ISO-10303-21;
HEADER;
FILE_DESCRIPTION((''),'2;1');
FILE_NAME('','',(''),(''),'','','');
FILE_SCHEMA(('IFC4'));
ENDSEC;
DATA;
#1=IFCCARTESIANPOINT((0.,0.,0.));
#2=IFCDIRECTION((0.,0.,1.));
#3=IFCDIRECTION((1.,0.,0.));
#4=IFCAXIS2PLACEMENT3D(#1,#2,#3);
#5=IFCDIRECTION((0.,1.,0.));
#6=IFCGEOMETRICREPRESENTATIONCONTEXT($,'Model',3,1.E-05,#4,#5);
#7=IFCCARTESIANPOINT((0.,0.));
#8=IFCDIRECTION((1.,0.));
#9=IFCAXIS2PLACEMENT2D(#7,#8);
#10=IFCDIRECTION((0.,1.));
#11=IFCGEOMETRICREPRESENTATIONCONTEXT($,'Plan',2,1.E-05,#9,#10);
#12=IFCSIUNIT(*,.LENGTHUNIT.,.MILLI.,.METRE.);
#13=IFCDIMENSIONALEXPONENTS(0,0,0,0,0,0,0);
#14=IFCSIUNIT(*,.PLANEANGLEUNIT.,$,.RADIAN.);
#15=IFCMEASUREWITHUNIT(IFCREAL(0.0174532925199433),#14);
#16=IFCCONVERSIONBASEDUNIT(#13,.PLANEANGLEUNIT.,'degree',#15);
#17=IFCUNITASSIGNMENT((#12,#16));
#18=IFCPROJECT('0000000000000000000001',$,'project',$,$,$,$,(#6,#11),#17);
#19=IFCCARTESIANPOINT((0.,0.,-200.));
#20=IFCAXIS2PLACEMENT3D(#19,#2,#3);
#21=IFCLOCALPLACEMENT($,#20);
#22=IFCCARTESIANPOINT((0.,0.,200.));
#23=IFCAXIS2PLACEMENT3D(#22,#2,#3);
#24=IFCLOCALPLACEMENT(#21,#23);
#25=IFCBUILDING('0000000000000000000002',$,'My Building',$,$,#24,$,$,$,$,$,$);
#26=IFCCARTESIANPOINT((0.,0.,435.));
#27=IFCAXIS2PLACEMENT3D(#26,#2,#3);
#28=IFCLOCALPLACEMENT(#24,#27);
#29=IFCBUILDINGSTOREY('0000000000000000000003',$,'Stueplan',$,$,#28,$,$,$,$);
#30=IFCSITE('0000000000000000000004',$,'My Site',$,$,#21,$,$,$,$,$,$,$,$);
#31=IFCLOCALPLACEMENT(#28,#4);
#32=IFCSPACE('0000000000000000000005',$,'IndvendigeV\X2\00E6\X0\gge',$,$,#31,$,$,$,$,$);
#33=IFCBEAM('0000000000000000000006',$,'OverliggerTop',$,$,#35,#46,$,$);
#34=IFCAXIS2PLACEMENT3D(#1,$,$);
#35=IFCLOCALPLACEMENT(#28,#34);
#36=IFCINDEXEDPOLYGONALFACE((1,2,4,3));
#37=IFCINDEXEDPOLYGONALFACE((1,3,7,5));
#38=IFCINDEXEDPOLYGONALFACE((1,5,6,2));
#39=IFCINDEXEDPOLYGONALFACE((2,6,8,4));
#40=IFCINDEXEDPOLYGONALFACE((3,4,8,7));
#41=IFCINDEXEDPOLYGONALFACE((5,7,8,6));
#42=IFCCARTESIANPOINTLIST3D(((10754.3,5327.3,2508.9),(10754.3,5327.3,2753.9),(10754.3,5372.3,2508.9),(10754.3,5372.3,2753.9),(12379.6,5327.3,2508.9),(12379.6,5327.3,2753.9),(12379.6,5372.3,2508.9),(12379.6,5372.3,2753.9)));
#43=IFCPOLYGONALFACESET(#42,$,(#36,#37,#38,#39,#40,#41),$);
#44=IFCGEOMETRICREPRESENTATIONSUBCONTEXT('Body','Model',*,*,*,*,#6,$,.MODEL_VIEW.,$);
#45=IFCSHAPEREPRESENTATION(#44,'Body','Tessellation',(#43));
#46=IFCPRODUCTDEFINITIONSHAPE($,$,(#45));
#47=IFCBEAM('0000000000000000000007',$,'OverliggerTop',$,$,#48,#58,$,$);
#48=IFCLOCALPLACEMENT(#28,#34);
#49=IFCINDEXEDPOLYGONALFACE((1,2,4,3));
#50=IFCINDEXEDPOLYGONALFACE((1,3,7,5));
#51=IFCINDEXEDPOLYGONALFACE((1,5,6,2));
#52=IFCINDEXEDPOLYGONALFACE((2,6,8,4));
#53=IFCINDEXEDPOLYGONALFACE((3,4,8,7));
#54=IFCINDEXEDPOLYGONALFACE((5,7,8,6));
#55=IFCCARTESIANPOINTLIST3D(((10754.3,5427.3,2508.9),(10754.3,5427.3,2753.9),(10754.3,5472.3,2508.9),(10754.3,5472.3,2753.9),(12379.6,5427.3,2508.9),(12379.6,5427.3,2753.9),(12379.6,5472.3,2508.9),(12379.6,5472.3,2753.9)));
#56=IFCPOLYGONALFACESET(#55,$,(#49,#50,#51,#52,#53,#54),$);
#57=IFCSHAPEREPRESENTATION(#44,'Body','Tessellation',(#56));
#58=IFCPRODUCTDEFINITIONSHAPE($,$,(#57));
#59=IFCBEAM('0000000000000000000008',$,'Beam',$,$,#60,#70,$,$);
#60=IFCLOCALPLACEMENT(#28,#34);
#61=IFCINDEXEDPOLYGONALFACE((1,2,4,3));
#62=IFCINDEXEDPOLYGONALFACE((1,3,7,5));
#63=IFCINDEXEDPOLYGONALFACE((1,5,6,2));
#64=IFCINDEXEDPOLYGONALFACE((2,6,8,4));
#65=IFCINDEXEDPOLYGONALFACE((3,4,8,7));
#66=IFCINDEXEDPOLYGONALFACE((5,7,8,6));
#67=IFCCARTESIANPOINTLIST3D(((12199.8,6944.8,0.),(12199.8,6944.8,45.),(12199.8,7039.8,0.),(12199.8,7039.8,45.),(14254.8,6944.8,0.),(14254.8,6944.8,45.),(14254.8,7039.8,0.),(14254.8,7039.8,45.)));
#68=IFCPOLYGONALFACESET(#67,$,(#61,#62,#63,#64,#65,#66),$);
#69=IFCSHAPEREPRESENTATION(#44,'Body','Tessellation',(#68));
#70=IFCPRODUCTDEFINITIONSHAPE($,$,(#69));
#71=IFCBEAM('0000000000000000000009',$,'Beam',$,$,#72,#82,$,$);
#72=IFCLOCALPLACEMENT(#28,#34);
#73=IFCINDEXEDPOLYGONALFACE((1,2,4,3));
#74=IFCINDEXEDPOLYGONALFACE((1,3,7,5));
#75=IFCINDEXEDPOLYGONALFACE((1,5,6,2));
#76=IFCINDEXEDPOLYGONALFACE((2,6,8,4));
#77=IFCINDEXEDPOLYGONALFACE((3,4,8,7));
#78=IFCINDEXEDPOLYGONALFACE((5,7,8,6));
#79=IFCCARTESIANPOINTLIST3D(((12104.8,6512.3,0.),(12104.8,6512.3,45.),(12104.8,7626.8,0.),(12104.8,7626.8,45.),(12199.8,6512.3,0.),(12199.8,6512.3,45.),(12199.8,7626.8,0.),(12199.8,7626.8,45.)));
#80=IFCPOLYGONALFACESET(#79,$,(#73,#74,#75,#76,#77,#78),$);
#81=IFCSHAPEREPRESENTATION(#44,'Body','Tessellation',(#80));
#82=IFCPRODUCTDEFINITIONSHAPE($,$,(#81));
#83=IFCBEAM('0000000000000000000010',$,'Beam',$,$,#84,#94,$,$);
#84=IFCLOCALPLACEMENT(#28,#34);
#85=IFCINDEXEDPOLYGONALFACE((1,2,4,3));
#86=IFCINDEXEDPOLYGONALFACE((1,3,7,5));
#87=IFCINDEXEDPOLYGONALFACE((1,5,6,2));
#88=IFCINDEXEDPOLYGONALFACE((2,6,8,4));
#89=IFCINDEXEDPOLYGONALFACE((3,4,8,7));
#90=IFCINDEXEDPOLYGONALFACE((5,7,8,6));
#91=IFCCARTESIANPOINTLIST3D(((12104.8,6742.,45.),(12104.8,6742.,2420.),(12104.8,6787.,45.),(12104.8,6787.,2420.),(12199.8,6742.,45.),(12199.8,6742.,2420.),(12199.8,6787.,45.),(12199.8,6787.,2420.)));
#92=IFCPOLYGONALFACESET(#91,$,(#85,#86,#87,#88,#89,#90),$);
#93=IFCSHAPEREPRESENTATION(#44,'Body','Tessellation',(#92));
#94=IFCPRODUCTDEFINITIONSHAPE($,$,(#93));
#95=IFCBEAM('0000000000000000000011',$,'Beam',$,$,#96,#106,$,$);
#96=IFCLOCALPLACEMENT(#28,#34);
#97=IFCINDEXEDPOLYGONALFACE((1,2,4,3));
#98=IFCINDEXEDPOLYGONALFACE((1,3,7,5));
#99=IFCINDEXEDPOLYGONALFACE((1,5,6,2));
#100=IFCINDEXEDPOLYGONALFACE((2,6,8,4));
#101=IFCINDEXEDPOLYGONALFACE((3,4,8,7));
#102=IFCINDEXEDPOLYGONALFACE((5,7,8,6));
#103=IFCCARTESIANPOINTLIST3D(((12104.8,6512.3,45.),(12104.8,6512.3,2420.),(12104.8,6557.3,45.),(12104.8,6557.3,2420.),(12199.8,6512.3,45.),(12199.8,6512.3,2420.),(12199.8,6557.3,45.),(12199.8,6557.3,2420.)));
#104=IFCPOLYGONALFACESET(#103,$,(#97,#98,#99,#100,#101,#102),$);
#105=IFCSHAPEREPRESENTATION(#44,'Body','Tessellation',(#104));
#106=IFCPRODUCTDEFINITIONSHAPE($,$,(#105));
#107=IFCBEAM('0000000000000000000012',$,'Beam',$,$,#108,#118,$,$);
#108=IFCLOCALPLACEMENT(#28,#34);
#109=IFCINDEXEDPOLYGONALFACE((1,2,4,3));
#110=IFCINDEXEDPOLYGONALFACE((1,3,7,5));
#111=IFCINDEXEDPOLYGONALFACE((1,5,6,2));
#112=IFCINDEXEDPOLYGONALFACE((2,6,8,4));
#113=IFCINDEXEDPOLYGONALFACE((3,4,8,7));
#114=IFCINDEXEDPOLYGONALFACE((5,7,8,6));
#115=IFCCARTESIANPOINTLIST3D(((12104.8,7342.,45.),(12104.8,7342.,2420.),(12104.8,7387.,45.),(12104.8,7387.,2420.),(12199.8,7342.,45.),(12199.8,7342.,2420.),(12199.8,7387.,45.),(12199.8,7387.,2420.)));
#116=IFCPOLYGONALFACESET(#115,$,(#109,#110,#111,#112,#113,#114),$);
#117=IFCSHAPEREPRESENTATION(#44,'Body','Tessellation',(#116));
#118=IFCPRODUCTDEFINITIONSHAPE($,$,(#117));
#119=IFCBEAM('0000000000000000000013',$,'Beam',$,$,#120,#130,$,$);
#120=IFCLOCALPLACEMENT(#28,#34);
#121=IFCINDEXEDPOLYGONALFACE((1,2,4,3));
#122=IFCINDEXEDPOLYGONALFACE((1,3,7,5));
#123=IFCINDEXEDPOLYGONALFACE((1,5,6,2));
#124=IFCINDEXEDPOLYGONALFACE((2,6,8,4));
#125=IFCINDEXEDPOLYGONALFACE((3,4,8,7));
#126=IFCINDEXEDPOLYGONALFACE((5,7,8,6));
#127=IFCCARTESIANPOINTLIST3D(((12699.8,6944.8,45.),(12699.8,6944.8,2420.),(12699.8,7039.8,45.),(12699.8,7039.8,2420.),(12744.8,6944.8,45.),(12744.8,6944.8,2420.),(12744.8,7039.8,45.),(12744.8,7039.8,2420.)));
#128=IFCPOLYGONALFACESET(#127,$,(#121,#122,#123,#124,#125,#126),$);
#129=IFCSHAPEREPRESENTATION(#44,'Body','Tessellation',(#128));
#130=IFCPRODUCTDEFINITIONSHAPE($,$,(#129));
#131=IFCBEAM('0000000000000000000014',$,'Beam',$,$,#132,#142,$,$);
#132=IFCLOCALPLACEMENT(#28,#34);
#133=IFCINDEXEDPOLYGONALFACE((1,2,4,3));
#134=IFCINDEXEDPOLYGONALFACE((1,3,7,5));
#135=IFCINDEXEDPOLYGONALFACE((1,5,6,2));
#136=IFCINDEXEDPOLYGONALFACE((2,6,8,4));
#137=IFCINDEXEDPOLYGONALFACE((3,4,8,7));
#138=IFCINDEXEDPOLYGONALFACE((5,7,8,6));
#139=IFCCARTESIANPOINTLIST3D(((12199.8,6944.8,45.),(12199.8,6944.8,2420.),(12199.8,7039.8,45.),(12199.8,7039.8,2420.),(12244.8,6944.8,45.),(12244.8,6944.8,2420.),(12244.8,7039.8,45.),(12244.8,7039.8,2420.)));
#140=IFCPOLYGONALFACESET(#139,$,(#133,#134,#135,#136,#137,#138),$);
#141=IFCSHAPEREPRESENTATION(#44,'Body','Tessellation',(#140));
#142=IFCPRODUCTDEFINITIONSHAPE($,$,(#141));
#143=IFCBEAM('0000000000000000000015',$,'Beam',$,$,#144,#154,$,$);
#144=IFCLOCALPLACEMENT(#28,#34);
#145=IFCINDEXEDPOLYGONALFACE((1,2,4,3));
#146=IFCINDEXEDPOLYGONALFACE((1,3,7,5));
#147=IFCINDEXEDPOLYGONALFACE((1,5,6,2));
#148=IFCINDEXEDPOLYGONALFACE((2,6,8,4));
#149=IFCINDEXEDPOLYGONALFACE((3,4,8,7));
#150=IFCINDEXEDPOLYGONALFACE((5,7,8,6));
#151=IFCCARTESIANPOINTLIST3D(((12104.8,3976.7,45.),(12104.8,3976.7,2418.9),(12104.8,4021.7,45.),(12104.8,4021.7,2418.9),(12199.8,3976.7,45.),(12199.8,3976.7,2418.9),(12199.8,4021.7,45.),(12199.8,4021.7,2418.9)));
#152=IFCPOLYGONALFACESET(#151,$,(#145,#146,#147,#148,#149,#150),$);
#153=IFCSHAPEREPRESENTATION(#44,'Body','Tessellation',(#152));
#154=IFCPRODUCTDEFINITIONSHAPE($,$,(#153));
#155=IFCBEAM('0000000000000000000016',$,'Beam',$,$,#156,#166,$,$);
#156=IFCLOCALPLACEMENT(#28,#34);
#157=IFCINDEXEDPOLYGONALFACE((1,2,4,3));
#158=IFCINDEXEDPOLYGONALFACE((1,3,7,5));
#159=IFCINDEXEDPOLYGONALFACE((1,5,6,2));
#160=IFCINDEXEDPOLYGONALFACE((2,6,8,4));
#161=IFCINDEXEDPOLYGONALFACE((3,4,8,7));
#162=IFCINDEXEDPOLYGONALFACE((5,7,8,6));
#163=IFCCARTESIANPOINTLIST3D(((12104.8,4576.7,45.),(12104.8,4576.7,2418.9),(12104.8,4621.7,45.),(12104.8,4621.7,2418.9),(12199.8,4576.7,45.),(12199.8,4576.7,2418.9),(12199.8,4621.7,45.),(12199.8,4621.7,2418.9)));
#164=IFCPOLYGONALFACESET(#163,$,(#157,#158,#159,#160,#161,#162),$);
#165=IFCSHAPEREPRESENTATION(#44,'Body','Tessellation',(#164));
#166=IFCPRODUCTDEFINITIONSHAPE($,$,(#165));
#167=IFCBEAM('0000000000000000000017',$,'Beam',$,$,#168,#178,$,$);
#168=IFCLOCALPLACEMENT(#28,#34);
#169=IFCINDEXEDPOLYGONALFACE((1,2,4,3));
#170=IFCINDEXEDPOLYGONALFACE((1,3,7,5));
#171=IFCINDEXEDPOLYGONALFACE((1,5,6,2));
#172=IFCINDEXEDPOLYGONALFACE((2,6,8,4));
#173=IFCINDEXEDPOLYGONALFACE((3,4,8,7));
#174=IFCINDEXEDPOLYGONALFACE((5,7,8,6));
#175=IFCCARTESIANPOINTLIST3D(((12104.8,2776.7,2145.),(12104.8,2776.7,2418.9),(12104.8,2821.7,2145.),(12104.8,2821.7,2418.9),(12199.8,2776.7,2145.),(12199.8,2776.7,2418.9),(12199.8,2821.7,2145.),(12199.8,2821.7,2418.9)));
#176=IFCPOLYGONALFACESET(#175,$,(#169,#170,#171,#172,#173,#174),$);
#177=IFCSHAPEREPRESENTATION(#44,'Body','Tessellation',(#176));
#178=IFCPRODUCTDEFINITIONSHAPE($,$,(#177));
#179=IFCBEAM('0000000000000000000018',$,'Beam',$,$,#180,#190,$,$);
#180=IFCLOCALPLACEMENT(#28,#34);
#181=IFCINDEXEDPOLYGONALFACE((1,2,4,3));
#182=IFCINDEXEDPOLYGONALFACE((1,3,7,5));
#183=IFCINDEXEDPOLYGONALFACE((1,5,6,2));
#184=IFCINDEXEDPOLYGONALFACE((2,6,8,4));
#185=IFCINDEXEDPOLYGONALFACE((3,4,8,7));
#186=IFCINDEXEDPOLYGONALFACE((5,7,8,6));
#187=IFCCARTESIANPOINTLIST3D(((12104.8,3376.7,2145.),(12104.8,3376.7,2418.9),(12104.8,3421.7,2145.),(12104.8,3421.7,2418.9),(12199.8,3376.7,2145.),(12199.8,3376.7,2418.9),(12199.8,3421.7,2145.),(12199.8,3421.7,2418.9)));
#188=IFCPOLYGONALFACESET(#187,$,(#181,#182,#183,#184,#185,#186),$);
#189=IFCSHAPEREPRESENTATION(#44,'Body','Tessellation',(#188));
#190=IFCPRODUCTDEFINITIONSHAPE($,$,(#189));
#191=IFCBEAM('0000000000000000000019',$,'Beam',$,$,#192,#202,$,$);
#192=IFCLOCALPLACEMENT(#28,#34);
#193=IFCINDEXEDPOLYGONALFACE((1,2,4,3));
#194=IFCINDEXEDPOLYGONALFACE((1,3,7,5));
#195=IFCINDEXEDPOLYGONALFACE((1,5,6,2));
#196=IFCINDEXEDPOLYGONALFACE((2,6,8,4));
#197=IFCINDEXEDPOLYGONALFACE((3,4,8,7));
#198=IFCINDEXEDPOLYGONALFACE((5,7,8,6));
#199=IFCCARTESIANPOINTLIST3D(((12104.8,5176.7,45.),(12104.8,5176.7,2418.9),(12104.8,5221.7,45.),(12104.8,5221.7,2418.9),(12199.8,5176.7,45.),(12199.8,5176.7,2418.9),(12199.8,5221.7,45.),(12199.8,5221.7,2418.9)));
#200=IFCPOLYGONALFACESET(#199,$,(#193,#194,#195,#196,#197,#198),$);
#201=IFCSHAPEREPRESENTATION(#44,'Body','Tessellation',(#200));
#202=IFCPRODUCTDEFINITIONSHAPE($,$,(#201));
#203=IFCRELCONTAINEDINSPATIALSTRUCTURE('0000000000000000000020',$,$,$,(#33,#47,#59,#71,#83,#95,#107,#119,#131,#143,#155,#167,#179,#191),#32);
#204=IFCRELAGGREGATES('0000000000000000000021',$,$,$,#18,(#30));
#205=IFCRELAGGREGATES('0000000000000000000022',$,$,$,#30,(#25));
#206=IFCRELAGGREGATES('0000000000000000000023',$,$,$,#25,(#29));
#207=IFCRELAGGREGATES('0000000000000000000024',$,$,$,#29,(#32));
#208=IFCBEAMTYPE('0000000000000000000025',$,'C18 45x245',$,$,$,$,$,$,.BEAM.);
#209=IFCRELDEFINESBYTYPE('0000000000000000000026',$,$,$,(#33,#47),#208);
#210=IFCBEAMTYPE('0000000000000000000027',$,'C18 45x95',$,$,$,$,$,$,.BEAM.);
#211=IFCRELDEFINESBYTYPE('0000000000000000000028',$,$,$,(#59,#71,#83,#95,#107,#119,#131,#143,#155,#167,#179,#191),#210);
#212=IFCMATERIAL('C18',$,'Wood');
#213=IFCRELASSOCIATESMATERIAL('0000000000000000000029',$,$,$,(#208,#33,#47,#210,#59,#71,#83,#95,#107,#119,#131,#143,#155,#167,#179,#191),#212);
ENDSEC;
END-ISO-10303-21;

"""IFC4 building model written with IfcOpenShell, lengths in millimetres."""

from ifc_helpers import new_model, entity, si_unit, converted_unit, direction, frame, origin_with_axes, origin_2d_with_axis, place, context, subcontext, project, spatial, rectangle, extrude, material, material_profile, profile_set, profile_usage, type_object, element, save


model = new_model("IFC4")

# Units and contexts
model_context = context("Model", 3, precision=1e-05, world=origin_with_axes(), true_north=direction((0.0, 1.0, 0.0)))
plan_context = context("Plan", 2, precision=1e-05, world=origin_2d_with_axis(), true_north=direction((0.0, 1.0)))
body_context_1 = subcontext(model_context, "Body", "Model", "MODEL_VIEW")
ifc_project = project(units=[si_unit("LENGTHUNIT", "METRE", prefix="MILLI"), converted_unit("PLANEANGLEUNIT", "degree", entity("IfcReal", 0.0174532925199433), si_unit("PLANEANGLEUNIT", "RADIAN"), dimensions=[0, 0, 0, 0, 0, 0, 0])], contexts=[model_context, plan_context])

# Site, building, storey, space
site_placement = place(None, frame((0.0, 0.0, -200.0), z_axis=(0.0, 0.0, 1.0), x_axis=(1.0, 0.0, 0.0)))
site = spatial("IfcSite", under=ifc_project, at=site_placement, Name="My Site")
building_placement = place(site_placement, frame((0.0, 0.0, 200.0), z_axis=(0.0, 0.0, 1.0), x_axis=(1.0, 0.0, 0.0)))
building = spatial("IfcBuilding", under=site, at=building_placement, Name="My Building")
storey_placement = place(building_placement, frame((0.0, 0.0, 435.0), z_axis=(0.0, 0.0, 1.0), x_axis=(1.0, 0.0, 0.0)))
storey = spatial("IfcBuildingStorey", under=building, at=storey_placement, Name="Stueplan")
space_1_placement = place(storey_placement, frame((0.0, 0.0, 0.0), z_axis=(0.0, 0.0, 1.0), x_axis=(1.0, 0.0, 0.0)))
space_1 = spatial("IfcSpace", under=storey, at=space_1_placement, Name="IndvendigeVægge")

# Beams
ifc_material = material(Name="C18", Category="Wood")
ifc_material_profile_1 = material_profile(ifc_material, rectangle(XDim=45.0, YDim=245.0), Name="concrete")
ifc_profile_set_1 = profile_set([ifc_material_profile_1], Name="woodStructural")
ifc_profile_usage_1 = profile_usage(ifc_profile_set_1)
beam_type_1 = type_object("IfcBeamType", Name="C18 45x245", PredefinedType="BEAM", material=ifc_profile_set_1)
beam_1_placement = place(space_1_placement, frame((12379.6, 5349.8, 2631.4), z_axis=(-1.0, 0.0, 0.0), x_axis=(0.0, 1.0, 0.0)))
element("IfcBeam", 1, at=beam_1_placement, inside=space_1, type_object=beam_type_1, material=ifc_profile_usage_1, Name="OverliggerTop", context=body_context_1, shape_type="SweptSolid", body=[
    extrude(rectangle(XDim=45.0, YDim=245.0), origin_with_axes(), (0.0, 0.0, 1.0), 1625.3),
])
ifc_profile_usage_2 = profile_usage(ifc_profile_set_1)
beam_2_placement = place(space_1_placement, frame((12379.6, 5449.8, 2631.4), z_axis=(-1.0, 0.0, 0.0), x_axis=(0.0, 1.0, 0.0)))
element("IfcBeam", 2, at=beam_2_placement, inside=space_1, type_object=beam_type_1, material=ifc_profile_usage_2, Name="OverliggerTop", context=body_context_1, shape_type="SweptSolid", body=[
    extrude(rectangle(XDim=45.0, YDim=245.0), origin_with_axes(), (0.0, 0.0, 1.0), 1625.3),
])
ifc_material_profile_2 = material_profile(ifc_material, rectangle(XDim=45.0, YDim=95.0))
ifc_profile_set_2 = profile_set([ifc_material_profile_2], Name="woodStructural")
ifc_profile_usage_3 = profile_usage(ifc_profile_set_2, cardinal=5)
beam_type_2 = type_object("IfcBeamType", Name="C18 45x95", PredefinedType="BEAM", material=ifc_profile_set_2)
beam_3_placement = place(space_1_placement, frame((12199.8, 6992.3, 22.5), z_axis=(1.0, 0.0, 0.0), x_axis=(0.0, 0.0, 1.0)))
element("IfcBeam", 3, at=beam_3_placement, inside=space_1, type_object=beam_type_2, material=ifc_profile_usage_3, Name="Beam", context=body_context_1, shape_type="SweptSolid", body=[
    extrude(rectangle(XDim=45.0, YDim=95.0), origin_with_axes(), (0.0, 0.0, 1.0), 2055.0),
])
ifc_profile_usage_4 = profile_usage(ifc_profile_set_2, cardinal=5)
beam_4_placement = place(space_1_placement, frame((12152.3, 6512.3, 22.5), z_axis=(0.0, 1.0, 0.0), x_axis=(0.0, 0.0, 1.0)))
element("IfcBeam", 4, at=beam_4_placement, inside=space_1, type_object=beam_type_2, material=ifc_profile_usage_4, Name="Beam", context=body_context_1, shape_type="SweptSolid", body=[
    extrude(rectangle(XDim=45.0, YDim=95.0), origin_with_axes(), (0.0, 0.0, 1.0), 1114.5),
])
ifc_profile_usage_5 = profile_usage(ifc_profile_set_2)
beam_5_placement = place(space_1_placement, frame((12152.3, 6764.5, 45.0), z_axis=(0.0, 0.0, 1.0), x_axis=(0.0, 1.0, 0.0)))
element("IfcBeam", 5, at=beam_5_placement, inside=space_1, type_object=beam_type_2, material=ifc_profile_usage_5, Name="Beam", context=body_context_1, shape_type="SweptSolid", body=[
    extrude(rectangle(XDim=45.0, YDim=95.0), origin_with_axes(), (0.0, 0.0, 1.0), 2375.0),
])
ifc_profile_usage_6 = profile_usage(ifc_profile_set_2)
beam_6_placement = place(space_1_placement, frame((12152.3, 6534.8, 45.0), z_axis=(0.0, 0.0, 1.0), x_axis=(0.0, 1.0, 0.0)))
element("IfcBeam", 6, at=beam_6_placement, inside=space_1, type_object=beam_type_2, material=ifc_profile_usage_6, Name="Beam", context=body_context_1, shape_type="SweptSolid", body=[
    extrude(rectangle(XDim=45.0, YDim=95.0), origin_with_axes(), (0.0, 0.0, 1.0), 2375.0),
])
ifc_profile_usage_7 = profile_usage(ifc_profile_set_2)
beam_7_placement = place(space_1_placement, frame((12152.3, 7364.5, 45.0), z_axis=(0.0, 0.0, 1.0), x_axis=(0.0, 1.0, 0.0)))
element("IfcBeam", 7, at=beam_7_placement, inside=space_1, type_object=beam_type_2, material=ifc_profile_usage_7, Name="Beam", context=body_context_1, shape_type="SweptSolid", body=[
    extrude(rectangle(XDim=45.0, YDim=95.0), origin_with_axes(), (0.0, 0.0, 1.0), 2375.0),
])
ifc_profile_usage_8 = profile_usage(ifc_profile_set_2)
beam_8_placement = place(space_1_placement, frame((12722.3, 6992.3, 45.0), z_axis=(0.0, 0.0, 1.0), x_axis=(-1.0, 0.0, 0.0)))
element("IfcBeam", 8, at=beam_8_placement, inside=space_1, type_object=beam_type_2, material=ifc_profile_usage_8, Name="Beam", context=body_context_1, shape_type="SweptSolid", body=[
    extrude(rectangle(XDim=45.0, YDim=95.0), origin_with_axes(), (0.0, 0.0, 1.0), 2375.0),
])
ifc_profile_usage_9 = profile_usage(ifc_profile_set_2)
beam_9_placement = place(space_1_placement, frame((12222.3, 6992.3, 45.0), z_axis=(0.0, 0.0, 1.0), x_axis=(-1.0, 0.0, 0.0)))
element("IfcBeam", 9, at=beam_9_placement, inside=space_1, type_object=beam_type_2, material=ifc_profile_usage_9, Name="Beam", context=body_context_1, shape_type="SweptSolid", body=[
    extrude(rectangle(XDim=45.0, YDim=95.0), origin_with_axes(), (0.0, 0.0, 1.0), 2375.0),
])
ifc_profile_usage_10 = profile_usage(ifc_profile_set_2)
beam_10_placement = place(space_1_placement, frame((12152.3, 3999.2, 45.0), z_axis=(0.0, 0.0, 1.0), x_axis=(0.0, -1.0, 0.0)))
element("IfcBeam", 10, at=beam_10_placement, inside=space_1, type_object=beam_type_2, material=ifc_profile_usage_10, Name="Beam", context=body_context_1, shape_type="SweptSolid", body=[
    extrude(rectangle(XDim=45.0, YDim=95.0), origin_with_axes(), (0.0, 0.0, 1.0), 2373.9),
])
ifc_profile_usage_11 = profile_usage(ifc_profile_set_2)
beam_11_placement = place(space_1_placement, frame((12152.3, 4599.2, 45.0), z_axis=(0.0, 0.0, 1.0), x_axis=(0.0, -1.0, 0.0)))
element("IfcBeam", 11, at=beam_11_placement, inside=space_1, type_object=beam_type_2, material=ifc_profile_usage_11, Name="Beam", context=body_context_1, shape_type="SweptSolid", body=[
    extrude(rectangle(XDim=45.0, YDim=95.0), origin_with_axes(), (0.0, 0.0, 1.0), 2373.9),
])
ifc_profile_usage_12 = profile_usage(ifc_profile_set_2)
beam_12_placement = place(space_1_placement, frame((12152.3, 2799.2, 2145.0), z_axis=(0.0, 0.0, 1.0), x_axis=(0.0, -1.0, 0.0)))
element("IfcBeam", 12, at=beam_12_placement, inside=space_1, type_object=beam_type_2, material=ifc_profile_usage_12, Name="Beam", context=body_context_1, shape_type="SweptSolid", body=[
    extrude(rectangle(XDim=45.0, YDim=95.0), origin_with_axes(), (0.0, 0.0, 1.0), 273.9),
])
ifc_profile_usage_13 = profile_usage(ifc_profile_set_2)
beam_13_placement = place(space_1_placement, frame((12152.3, 3399.2, 2145.0), z_axis=(0.0, 0.0, 1.0), x_axis=(0.0, -1.0, 0.0)))
element("IfcBeam", 13, at=beam_13_placement, inside=space_1, type_object=beam_type_2, material=ifc_profile_usage_13, Name="Beam", context=body_context_1, shape_type="SweptSolid", body=[
    extrude(rectangle(XDim=45.0, YDim=95.0), origin_with_axes(), (0.0, 0.0, 1.0), 273.9),
])
ifc_profile_usage_14 = profile_usage(ifc_profile_set_2)
beam_14_placement = place(space_1_placement, frame((12152.3, 5199.2, 45.0), z_axis=(0.0, 0.0, 1.0), x_axis=(0.0, -1.0, 0.0)))
element("IfcBeam", 14, at=beam_14_placement, inside=space_1, type_object=beam_type_2, material=ifc_profile_usage_14, Name="Beam", context=body_context_1, shape_type="SweptSolid", body=[
    extrude(rectangle(XDim=45.0, YDim=95.0), origin_with_axes(), (0.0, 0.0, 1.0), 2373.9),
])

save(model, "model.ifc")
